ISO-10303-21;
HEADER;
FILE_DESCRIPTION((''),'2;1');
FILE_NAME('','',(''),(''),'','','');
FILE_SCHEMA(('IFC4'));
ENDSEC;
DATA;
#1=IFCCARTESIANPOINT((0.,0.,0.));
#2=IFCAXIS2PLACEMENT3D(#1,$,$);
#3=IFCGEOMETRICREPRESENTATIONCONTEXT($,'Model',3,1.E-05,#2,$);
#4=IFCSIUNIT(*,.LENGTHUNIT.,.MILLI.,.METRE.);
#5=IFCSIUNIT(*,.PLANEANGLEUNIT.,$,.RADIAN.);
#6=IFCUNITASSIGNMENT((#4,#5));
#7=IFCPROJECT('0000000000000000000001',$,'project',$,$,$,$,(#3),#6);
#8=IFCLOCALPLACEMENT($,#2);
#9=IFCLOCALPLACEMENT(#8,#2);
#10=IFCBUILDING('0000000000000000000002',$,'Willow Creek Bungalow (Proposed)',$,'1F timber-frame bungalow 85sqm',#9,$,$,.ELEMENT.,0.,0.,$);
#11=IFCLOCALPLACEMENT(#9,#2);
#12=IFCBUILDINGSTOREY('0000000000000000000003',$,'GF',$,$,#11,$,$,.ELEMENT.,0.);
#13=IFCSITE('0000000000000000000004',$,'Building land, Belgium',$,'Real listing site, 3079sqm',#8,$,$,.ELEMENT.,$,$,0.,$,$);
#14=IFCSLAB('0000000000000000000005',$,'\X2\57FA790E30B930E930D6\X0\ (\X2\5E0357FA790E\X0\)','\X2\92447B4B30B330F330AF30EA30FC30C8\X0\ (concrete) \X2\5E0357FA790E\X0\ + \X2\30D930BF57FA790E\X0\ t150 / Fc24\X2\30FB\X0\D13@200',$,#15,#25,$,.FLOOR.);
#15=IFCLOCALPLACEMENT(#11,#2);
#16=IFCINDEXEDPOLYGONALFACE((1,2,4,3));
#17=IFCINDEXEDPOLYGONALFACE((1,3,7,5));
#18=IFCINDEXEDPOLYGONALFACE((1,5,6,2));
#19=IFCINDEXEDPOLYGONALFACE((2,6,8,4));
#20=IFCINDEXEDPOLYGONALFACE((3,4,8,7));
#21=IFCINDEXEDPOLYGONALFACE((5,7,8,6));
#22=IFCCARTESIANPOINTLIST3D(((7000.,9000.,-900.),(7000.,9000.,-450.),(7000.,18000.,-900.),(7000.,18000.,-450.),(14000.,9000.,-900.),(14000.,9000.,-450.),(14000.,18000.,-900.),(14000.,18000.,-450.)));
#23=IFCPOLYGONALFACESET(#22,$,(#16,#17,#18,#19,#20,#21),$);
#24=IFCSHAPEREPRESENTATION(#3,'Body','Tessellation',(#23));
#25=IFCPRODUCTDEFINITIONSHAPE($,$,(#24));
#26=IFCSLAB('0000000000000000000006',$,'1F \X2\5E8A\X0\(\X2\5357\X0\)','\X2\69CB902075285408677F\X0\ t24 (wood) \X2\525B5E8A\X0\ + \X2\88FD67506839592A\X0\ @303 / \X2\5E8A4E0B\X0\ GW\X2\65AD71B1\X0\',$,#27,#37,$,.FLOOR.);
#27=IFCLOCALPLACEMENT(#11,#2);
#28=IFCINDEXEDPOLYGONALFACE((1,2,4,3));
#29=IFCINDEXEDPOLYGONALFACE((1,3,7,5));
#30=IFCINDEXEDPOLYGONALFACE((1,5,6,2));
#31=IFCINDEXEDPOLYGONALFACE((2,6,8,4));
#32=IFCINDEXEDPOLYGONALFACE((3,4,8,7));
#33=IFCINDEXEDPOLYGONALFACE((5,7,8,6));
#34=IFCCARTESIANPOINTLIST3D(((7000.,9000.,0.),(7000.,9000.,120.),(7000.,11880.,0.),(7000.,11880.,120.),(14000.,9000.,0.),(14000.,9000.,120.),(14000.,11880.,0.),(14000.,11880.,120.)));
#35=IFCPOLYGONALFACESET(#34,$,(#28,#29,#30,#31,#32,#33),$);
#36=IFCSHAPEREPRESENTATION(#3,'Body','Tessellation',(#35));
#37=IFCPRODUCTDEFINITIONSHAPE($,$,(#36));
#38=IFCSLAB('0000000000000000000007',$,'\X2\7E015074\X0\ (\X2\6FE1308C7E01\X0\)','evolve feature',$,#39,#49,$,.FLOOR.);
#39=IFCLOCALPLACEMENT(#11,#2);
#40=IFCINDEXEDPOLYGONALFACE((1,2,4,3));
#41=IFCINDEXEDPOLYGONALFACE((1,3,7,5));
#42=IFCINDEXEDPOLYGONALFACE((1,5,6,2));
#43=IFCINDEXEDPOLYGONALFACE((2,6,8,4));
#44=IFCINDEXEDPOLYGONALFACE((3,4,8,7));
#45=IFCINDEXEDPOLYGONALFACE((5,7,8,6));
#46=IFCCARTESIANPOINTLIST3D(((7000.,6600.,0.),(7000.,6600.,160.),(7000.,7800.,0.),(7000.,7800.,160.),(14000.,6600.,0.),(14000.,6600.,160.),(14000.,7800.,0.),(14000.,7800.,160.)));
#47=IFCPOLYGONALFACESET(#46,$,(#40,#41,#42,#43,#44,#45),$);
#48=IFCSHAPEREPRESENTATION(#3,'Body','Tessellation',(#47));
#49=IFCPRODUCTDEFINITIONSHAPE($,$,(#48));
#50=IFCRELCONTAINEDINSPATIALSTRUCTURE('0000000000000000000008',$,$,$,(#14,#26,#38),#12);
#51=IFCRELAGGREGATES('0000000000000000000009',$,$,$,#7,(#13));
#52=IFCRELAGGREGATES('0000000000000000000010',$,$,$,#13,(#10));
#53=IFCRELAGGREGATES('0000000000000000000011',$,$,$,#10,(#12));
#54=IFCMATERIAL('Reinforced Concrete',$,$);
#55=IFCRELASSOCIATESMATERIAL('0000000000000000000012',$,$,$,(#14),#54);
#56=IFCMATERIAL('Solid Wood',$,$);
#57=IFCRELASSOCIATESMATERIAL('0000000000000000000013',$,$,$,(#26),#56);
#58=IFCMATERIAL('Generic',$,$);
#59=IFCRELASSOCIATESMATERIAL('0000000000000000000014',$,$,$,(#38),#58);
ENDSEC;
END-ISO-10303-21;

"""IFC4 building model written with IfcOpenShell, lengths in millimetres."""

from ifc_helpers import new_model, si_unit, frame, frame_2d, origin, place, context, project, spatial, rectangle, extrude, material, element, save


model = new_model("IFC4")

# Units and contexts
model_context = context("Model", 3, precision=1e-05, world=origin())
ifc_project = project(units=[si_unit("LENGTHUNIT", "METRE", prefix="MILLI"), si_unit("PLANEANGLEUNIT", "RADIAN")], contexts=[model_context])

# Site, building, storey
site_placement = place(None, origin())
site = spatial("IfcSite", under=ifc_project, at=site_placement, Name="Building land, Belgium", ObjectType="Real listing site, 3079sqm", CompositionType="ELEMENT", RefElevation=0.0)
building_placement = place(site_placement, origin())
building = spatial("IfcBuilding", under=site, at=building_placement, Name="Willow Creek Bungalow (Proposed)", ObjectType="1F timber-frame bungalow 85sqm", CompositionType="ELEMENT", ElevationOfRefHeight=0.0, ElevationOfTerrain=0.0)
storey_placement = place(building_placement, origin())
storey = spatial("IfcBuildingStorey", under=building, at=storey_placement, Name="GF", CompositionType="ELEMENT", Elevation=0.0)

# Slabs
ifc_material_1 = material(Name="Reinforced Concrete")
slab_1_placement = place(storey_placement, frame((3500.0, 4500.0, -450.0)))
element("IfcSlab", 1, at=slab_1_placement, inside=storey, material=ifc_material_1, Name="基礎スラブ (布基礎)", Description="鉄筋コンクリート (concrete) 布基礎 + ベタ基礎 t150 / Fc24・D13@200", PredefinedType="FLOOR", context=model_context, shape_type="SweptSolid", body=[
    extrude(rectangle(XDim=7000.0, YDim=9000.0, at=frame_2d((3500.0, 4500.0))), frame((3500.0, 4500.0, -450.0)), (0.0, 0.0, 1.0), 450.0),
])
ifc_material_2 = material(Name="Solid Wood")
slab_2_placement = place(storey_placement, frame((3500.0, 4500.0, 0.0)))
element("IfcSlab", 2, at=slab_2_placement, inside=storey, material=ifc_material_2, Name="1F 床(南)", Description="構造用合板 t24 (wood) 剛床 + 製材根太 @303 / 床下 GW断熱", PredefinedType="FLOOR", context=model_context, shape_type="SweptSolid", body=[
    extrude(rectangle(XDim=7000.0, YDim=2880.0, at=frame_2d((3500.0, 1440.0))), frame((3500.0, 4500.0, 0.0)), (0.0, 0.0, 1.0), 120.0),
])
ifc_material_3 = material(Name="Generic")
slab_3_placement = place(storey_placement, frame((3500.0, 3300.0, 0.0)))
element("IfcSlab", 3, at=slab_3_placement, inside=storey, material=ifc_material_3, Name="縁側 (濡れ縁)", Description="evolve feature", PredefinedType="FLOOR", context=model_context, shape_type="SweptSolid", body=[
    extrude(rectangle(XDim=7000.0, YDim=1200.0, at=frame_2d((3500.0, 600.0))), frame((3500.0, 3300.0, 0.0)), (0.0, 0.0, 1.0), 160.0),
])

save(model, "model.ifc")
